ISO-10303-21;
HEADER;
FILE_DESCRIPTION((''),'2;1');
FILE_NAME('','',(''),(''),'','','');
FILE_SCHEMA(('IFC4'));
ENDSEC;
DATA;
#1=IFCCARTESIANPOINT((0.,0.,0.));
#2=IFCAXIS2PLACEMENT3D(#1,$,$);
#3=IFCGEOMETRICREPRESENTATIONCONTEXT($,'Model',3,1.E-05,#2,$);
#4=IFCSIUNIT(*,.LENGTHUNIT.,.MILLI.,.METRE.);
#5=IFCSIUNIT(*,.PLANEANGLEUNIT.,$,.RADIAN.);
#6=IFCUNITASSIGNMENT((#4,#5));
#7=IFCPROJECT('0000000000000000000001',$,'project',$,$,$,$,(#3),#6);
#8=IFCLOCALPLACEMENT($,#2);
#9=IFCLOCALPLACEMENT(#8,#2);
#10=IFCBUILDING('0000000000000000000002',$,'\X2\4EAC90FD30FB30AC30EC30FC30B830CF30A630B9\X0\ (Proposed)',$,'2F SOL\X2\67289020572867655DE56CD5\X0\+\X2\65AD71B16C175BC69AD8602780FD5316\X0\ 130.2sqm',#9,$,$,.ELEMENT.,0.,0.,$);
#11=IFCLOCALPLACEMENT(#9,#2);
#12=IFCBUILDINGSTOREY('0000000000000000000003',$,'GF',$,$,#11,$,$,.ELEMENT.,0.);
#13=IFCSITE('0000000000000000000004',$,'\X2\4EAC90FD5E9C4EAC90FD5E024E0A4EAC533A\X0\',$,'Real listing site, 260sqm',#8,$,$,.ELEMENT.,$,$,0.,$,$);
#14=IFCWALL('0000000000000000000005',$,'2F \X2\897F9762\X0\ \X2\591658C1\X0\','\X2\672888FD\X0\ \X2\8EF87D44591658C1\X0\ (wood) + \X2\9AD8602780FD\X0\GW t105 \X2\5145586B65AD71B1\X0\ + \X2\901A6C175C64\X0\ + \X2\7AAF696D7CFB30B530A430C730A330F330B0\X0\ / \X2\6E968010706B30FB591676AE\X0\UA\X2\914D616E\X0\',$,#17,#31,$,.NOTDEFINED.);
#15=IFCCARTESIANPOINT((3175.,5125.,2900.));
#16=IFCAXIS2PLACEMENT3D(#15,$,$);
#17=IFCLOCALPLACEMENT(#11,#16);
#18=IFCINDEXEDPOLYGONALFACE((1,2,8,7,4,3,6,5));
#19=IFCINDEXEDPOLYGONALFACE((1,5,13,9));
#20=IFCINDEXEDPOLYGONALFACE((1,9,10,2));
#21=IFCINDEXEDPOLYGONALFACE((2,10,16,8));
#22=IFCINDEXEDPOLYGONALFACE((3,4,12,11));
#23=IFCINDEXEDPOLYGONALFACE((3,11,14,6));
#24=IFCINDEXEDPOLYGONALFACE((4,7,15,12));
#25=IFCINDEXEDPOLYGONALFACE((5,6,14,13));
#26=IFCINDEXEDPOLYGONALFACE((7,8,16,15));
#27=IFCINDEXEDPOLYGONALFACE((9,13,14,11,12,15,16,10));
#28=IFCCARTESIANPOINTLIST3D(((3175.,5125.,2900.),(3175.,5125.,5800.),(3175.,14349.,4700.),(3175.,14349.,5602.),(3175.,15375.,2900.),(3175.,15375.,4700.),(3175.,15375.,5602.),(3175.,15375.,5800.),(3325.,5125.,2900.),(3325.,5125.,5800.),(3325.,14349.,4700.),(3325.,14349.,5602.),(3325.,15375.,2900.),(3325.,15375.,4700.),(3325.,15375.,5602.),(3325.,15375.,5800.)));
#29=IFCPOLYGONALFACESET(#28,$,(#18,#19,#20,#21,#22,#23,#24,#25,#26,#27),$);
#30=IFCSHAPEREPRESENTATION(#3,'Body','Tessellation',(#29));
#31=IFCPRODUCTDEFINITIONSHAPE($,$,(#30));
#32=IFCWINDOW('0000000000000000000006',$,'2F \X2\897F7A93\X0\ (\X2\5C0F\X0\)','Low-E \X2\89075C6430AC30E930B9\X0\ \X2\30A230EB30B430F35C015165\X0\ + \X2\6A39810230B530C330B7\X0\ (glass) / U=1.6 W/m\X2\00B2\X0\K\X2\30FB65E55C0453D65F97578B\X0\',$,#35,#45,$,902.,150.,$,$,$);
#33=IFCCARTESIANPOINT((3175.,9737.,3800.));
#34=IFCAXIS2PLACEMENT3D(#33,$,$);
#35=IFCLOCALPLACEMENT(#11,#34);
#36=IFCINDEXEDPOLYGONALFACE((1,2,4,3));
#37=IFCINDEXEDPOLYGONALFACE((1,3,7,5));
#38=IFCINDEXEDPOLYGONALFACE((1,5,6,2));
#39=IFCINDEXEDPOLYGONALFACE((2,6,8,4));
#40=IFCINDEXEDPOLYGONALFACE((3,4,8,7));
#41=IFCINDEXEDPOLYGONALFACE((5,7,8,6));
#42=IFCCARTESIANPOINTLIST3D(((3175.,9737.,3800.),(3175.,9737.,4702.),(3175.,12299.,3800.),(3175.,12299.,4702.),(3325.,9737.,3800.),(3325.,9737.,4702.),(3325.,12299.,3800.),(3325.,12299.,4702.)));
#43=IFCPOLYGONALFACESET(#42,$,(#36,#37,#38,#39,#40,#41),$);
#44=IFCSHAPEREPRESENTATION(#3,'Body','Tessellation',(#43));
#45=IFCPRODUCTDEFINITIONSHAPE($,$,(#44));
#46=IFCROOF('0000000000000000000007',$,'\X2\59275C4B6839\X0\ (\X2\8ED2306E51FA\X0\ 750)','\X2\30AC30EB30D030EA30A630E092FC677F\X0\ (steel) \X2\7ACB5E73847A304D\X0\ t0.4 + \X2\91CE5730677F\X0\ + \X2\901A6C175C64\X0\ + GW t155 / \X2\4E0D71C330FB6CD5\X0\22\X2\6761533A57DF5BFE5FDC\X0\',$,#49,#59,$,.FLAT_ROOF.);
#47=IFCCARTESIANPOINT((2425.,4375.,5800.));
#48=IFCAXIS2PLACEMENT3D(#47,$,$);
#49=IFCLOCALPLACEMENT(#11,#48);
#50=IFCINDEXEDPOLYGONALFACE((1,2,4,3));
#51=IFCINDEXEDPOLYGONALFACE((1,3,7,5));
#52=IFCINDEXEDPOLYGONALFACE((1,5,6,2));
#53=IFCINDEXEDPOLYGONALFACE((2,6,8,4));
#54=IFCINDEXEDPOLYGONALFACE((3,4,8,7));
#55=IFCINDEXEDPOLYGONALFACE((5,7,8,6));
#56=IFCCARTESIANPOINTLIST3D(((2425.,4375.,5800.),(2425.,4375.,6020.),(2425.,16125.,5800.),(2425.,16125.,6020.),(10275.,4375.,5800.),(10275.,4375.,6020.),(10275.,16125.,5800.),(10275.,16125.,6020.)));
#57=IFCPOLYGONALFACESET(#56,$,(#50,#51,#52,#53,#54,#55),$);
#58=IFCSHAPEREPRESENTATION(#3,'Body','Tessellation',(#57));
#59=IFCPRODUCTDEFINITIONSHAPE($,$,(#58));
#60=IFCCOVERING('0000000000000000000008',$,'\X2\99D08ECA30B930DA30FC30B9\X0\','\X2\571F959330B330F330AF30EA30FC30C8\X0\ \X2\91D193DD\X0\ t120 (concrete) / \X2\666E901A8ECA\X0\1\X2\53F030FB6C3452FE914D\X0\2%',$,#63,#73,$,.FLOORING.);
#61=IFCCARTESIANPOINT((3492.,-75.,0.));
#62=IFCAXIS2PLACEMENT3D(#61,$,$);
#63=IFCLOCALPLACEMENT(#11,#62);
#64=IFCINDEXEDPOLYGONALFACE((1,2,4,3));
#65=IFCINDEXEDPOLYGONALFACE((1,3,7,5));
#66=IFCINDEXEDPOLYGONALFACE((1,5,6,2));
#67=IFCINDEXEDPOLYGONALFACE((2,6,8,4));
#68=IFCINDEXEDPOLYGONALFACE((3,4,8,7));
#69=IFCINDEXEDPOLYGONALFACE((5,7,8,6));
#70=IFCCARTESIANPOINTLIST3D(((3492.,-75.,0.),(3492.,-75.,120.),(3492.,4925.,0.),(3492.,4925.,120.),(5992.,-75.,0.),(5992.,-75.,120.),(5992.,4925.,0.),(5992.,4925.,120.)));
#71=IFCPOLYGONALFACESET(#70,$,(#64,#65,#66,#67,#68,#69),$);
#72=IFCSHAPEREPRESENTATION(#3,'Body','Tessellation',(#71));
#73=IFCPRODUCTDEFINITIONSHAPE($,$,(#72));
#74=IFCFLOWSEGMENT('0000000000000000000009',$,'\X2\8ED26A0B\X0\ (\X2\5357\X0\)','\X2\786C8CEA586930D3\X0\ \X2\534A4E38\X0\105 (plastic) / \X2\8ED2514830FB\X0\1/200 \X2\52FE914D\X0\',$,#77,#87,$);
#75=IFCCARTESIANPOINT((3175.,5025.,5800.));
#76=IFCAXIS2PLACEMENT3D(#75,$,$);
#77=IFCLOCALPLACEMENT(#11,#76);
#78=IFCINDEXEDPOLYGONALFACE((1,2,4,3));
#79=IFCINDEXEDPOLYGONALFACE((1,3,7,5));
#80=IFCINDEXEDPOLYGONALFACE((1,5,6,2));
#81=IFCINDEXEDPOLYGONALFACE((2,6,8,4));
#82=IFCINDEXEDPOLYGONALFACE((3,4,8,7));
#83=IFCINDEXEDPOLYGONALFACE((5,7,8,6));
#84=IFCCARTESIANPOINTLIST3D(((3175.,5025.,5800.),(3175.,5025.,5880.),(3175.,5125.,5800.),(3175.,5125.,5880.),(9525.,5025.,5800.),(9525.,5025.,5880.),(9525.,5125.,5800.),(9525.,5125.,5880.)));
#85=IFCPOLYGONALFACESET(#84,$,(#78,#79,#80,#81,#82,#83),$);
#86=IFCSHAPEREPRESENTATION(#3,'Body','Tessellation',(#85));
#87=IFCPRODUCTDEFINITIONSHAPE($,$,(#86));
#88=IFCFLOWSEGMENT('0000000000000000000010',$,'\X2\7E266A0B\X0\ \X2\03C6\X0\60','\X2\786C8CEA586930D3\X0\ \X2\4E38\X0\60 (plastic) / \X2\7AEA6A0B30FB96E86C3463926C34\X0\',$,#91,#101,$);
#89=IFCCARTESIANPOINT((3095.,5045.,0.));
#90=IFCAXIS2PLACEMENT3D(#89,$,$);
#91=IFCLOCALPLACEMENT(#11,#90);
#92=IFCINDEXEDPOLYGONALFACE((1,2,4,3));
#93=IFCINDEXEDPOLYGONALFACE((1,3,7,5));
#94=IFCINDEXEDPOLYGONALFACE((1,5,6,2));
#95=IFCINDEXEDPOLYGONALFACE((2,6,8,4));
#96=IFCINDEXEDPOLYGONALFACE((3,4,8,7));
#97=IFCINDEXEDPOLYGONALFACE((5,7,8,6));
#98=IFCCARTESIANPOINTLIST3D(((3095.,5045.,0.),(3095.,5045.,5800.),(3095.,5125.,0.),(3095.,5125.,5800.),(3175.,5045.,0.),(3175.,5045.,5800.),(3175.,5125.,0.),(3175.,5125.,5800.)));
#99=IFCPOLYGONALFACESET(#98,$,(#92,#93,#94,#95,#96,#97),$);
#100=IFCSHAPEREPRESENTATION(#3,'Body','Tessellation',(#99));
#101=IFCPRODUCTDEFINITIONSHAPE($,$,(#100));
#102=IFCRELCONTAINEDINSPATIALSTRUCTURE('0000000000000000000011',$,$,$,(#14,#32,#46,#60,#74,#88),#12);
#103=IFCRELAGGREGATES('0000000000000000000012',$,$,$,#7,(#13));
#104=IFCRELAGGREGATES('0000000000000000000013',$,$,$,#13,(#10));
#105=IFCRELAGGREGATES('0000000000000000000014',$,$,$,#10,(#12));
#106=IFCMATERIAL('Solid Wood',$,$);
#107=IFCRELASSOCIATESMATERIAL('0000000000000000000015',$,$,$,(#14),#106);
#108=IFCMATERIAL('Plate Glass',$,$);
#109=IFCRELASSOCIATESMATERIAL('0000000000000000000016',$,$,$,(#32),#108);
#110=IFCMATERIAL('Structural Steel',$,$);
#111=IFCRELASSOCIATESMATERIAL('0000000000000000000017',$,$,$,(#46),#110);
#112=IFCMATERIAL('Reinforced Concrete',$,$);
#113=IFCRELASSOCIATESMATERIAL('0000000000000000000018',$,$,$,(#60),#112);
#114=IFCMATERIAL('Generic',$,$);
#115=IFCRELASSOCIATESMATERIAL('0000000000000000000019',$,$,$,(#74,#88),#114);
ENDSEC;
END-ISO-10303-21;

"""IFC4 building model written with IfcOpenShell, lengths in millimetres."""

from ifc_helpers import new_model, si_unit, frame, frame_2d, origin, place, context, project, spatial, rectangle, extrude, material, element, fill, save


model = new_model("IFC4")

# Units and contexts
model_context = context("Model", 3, precision=1e-05, world=origin())
ifc_project = project(units=[si_unit("LENGTHUNIT", "METRE", prefix="MILLI"), si_unit("PLANEANGLEUNIT", "RADIAN")], contexts=[model_context])

# Site, building, storey
site_placement = place(None, origin())
site = spatial("IfcSite", under=ifc_project, at=site_placement, Name="京都府京都市上京区", ObjectType="Real listing site, 260sqm", CompositionType="ELEMENT", RefElevation=0.0)
building_placement = place(site_placement, origin())
building = spatial("IfcBuilding", under=site, at=building_placement, Name="京都・ガレージハウス (Proposed)", ObjectType="2F SOL木造在来工法+断熱気密高性能化 130.2sqm", CompositionType="ELEMENT", ElevationOfRefHeight=0.0, ElevationOfTerrain=0.0)
storey_placement = place(building_placement, origin())
storey = spatial("IfcBuildingStorey", under=building, at=storey_placement, Name="GF", CompositionType="ELEMENT", Elevation=0.0)

# Shared definitions
ifc_material_1 = material(Name="Solid Wood")

# Shared definitions
ifc_material_2 = material(Name="Reinforced Concrete")

# Shared definitions
ifc_material_3 = material(Name="Plate Glass")

# Wall, opening, window
wall_1_placement = place(storey_placement, frame((3175.0, 5125.0, 2900.0)))
wall_1 = element("IfcWall", 1, at=wall_1_placement, inside=storey, material=ifc_material_1, Name="2F 西面 外壁", Description="木製 軸組外壁 (wood) + 高性能GW t105 充填断熱 + 通気層 + 窯業系サイディング / 準耐火・外皮UA配慮", PredefinedType="NOTDEFINED", context=model_context, shape_type="SweptSolid", body=[
    extrude(rectangle(XDim=150.0, YDim=10250.0, at=frame_2d((75.0, 5125.0))), frame((3175.0, 5125.0, 2900.0)), (0.0, 0.0, 1.0), 2900.0),
])
opening_1_placement = place(storey_placement, frame((3175.0, 9737.0, 3800.0)))
opening_1 = element("IfcOpeningElement", 2, at=opening_1_placement, cuts=wall_1, PredefinedType="NOTDEFINED", context=model_context, shape_type="SweptSolid", body=[
    extrude(rectangle(XDim=150.0, YDim=2562.0, at=frame_2d((75.0, 1281.0))), frame((3175.0, 9737.0, 3800.0)), (0.0, 0.0, 1.0), 902.0),
])
window_1_placement = place(storey_placement, frame((3175.0, 9737.0, 3800.0)))
window_1 = element("IfcWindow", 3, at=window_1_placement, inside=storey, material=ifc_material_3, Name="2F 西窓 (小)", Description="Low-E 複層ガラス アルゴン封入 + 樹脂サッシ (glass) / U=1.6 W/m²K・日射取得型", OverallHeight=902.0, OverallWidth=150.0, context=model_context, shape_type="SweptSolid", body=[
    extrude(rectangle(XDim=150.0, YDim=2562.0, at=frame_2d((75.0, 1281.0))), frame((3175.0, 9737.0, 3800.0)), (0.0, 0.0, 1.0), 902.0),
])
fill(opening_1, window_1)

# Roof
ifc_material_4 = material(Name="Structural Steel")
roof_placement = place(storey_placement, frame((2425.0, 4375.0, 5800.0)))
element("IfcRoof", 4, at=roof_placement, inside=storey, material=ifc_material_4, Name="大屋根 (軒の出 750)", Description="ガルバリウム鋼板 (steel) 立平葺き t0.4 + 野地板 + 通気層 + GW t155 / 不燃・法22条区域対応", PredefinedType="FLAT_ROOF", context=model_context, shape_type="SweptSolid", body=[
    extrude(rectangle(XDim=7850.0, YDim=11750.0, at=frame_2d((3925.0, 5875.0))), frame((2425.0, 4375.0, 5800.0)), (0.0, 0.0, 1.0), 220.0),
])

# Covering
covering_placement = place(storey_placement, frame((3492.0, -75.0, 0.0)))
element("IfcCovering", 5, at=covering_placement, inside=storey, material=ifc_material_2, Name="駐車スペース", Description="土間コンクリート 金鏝 t120 (concrete) / 普通車1台・水勾配2%", PredefinedType="FLOORING", context=model_context, shape_type="SweptSolid", body=[
    extrude(rectangle(XDim=2500.0, YDim=5000.0, at=frame_2d((1250.0, 2500.0))), frame((3492.0, -75.0, 0.0)), (0.0, 0.0, 1.0), 120.0),
])

# Flow segments
ifc_material_5 = material(Name="Generic")
flow_segment_1_placement = place(storey_placement, frame((3175.0, 5025.0, 5800.0)))
element("IfcFlowSegment", 6, at=flow_segment_1_placement, inside=storey, material=ifc_material_5, Name="軒樋 (南)", Description="硬質塩ビ 半丸105 (plastic) / 軒先・1/200 勾配", context=model_context, shape_type="SweptSolid", body=[
    extrude(rectangle(XDim=6350.0, YDim=100.0, at=frame_2d((3175.0, 50.0))), frame((3175.0, 5025.0, 5800.0)), (0.0, 0.0, 1.0), 80.0),
])
flow_segment_2_placement = place(storey_placement, frame((3095.0, 5045.0, 0.0)))
element("IfcFlowSegment", 7, at=flow_segment_2_placement, inside=storey, material=ifc_material_5, Name="縦樋 φ60", Description="硬質塩ビ 丸60 (plastic) / 竪樋・雨水排水", context=model_context, shape_type="SweptSolid", body=[
    extrude(rectangle(XDim=80.0, YDim=80.0, at=frame_2d((40.0, 40.0))), frame((3095.0, 5045.0, 0.0)), (0.0, 0.0, 1.0), 5800.0),
])

save(model, "model.ifc")
